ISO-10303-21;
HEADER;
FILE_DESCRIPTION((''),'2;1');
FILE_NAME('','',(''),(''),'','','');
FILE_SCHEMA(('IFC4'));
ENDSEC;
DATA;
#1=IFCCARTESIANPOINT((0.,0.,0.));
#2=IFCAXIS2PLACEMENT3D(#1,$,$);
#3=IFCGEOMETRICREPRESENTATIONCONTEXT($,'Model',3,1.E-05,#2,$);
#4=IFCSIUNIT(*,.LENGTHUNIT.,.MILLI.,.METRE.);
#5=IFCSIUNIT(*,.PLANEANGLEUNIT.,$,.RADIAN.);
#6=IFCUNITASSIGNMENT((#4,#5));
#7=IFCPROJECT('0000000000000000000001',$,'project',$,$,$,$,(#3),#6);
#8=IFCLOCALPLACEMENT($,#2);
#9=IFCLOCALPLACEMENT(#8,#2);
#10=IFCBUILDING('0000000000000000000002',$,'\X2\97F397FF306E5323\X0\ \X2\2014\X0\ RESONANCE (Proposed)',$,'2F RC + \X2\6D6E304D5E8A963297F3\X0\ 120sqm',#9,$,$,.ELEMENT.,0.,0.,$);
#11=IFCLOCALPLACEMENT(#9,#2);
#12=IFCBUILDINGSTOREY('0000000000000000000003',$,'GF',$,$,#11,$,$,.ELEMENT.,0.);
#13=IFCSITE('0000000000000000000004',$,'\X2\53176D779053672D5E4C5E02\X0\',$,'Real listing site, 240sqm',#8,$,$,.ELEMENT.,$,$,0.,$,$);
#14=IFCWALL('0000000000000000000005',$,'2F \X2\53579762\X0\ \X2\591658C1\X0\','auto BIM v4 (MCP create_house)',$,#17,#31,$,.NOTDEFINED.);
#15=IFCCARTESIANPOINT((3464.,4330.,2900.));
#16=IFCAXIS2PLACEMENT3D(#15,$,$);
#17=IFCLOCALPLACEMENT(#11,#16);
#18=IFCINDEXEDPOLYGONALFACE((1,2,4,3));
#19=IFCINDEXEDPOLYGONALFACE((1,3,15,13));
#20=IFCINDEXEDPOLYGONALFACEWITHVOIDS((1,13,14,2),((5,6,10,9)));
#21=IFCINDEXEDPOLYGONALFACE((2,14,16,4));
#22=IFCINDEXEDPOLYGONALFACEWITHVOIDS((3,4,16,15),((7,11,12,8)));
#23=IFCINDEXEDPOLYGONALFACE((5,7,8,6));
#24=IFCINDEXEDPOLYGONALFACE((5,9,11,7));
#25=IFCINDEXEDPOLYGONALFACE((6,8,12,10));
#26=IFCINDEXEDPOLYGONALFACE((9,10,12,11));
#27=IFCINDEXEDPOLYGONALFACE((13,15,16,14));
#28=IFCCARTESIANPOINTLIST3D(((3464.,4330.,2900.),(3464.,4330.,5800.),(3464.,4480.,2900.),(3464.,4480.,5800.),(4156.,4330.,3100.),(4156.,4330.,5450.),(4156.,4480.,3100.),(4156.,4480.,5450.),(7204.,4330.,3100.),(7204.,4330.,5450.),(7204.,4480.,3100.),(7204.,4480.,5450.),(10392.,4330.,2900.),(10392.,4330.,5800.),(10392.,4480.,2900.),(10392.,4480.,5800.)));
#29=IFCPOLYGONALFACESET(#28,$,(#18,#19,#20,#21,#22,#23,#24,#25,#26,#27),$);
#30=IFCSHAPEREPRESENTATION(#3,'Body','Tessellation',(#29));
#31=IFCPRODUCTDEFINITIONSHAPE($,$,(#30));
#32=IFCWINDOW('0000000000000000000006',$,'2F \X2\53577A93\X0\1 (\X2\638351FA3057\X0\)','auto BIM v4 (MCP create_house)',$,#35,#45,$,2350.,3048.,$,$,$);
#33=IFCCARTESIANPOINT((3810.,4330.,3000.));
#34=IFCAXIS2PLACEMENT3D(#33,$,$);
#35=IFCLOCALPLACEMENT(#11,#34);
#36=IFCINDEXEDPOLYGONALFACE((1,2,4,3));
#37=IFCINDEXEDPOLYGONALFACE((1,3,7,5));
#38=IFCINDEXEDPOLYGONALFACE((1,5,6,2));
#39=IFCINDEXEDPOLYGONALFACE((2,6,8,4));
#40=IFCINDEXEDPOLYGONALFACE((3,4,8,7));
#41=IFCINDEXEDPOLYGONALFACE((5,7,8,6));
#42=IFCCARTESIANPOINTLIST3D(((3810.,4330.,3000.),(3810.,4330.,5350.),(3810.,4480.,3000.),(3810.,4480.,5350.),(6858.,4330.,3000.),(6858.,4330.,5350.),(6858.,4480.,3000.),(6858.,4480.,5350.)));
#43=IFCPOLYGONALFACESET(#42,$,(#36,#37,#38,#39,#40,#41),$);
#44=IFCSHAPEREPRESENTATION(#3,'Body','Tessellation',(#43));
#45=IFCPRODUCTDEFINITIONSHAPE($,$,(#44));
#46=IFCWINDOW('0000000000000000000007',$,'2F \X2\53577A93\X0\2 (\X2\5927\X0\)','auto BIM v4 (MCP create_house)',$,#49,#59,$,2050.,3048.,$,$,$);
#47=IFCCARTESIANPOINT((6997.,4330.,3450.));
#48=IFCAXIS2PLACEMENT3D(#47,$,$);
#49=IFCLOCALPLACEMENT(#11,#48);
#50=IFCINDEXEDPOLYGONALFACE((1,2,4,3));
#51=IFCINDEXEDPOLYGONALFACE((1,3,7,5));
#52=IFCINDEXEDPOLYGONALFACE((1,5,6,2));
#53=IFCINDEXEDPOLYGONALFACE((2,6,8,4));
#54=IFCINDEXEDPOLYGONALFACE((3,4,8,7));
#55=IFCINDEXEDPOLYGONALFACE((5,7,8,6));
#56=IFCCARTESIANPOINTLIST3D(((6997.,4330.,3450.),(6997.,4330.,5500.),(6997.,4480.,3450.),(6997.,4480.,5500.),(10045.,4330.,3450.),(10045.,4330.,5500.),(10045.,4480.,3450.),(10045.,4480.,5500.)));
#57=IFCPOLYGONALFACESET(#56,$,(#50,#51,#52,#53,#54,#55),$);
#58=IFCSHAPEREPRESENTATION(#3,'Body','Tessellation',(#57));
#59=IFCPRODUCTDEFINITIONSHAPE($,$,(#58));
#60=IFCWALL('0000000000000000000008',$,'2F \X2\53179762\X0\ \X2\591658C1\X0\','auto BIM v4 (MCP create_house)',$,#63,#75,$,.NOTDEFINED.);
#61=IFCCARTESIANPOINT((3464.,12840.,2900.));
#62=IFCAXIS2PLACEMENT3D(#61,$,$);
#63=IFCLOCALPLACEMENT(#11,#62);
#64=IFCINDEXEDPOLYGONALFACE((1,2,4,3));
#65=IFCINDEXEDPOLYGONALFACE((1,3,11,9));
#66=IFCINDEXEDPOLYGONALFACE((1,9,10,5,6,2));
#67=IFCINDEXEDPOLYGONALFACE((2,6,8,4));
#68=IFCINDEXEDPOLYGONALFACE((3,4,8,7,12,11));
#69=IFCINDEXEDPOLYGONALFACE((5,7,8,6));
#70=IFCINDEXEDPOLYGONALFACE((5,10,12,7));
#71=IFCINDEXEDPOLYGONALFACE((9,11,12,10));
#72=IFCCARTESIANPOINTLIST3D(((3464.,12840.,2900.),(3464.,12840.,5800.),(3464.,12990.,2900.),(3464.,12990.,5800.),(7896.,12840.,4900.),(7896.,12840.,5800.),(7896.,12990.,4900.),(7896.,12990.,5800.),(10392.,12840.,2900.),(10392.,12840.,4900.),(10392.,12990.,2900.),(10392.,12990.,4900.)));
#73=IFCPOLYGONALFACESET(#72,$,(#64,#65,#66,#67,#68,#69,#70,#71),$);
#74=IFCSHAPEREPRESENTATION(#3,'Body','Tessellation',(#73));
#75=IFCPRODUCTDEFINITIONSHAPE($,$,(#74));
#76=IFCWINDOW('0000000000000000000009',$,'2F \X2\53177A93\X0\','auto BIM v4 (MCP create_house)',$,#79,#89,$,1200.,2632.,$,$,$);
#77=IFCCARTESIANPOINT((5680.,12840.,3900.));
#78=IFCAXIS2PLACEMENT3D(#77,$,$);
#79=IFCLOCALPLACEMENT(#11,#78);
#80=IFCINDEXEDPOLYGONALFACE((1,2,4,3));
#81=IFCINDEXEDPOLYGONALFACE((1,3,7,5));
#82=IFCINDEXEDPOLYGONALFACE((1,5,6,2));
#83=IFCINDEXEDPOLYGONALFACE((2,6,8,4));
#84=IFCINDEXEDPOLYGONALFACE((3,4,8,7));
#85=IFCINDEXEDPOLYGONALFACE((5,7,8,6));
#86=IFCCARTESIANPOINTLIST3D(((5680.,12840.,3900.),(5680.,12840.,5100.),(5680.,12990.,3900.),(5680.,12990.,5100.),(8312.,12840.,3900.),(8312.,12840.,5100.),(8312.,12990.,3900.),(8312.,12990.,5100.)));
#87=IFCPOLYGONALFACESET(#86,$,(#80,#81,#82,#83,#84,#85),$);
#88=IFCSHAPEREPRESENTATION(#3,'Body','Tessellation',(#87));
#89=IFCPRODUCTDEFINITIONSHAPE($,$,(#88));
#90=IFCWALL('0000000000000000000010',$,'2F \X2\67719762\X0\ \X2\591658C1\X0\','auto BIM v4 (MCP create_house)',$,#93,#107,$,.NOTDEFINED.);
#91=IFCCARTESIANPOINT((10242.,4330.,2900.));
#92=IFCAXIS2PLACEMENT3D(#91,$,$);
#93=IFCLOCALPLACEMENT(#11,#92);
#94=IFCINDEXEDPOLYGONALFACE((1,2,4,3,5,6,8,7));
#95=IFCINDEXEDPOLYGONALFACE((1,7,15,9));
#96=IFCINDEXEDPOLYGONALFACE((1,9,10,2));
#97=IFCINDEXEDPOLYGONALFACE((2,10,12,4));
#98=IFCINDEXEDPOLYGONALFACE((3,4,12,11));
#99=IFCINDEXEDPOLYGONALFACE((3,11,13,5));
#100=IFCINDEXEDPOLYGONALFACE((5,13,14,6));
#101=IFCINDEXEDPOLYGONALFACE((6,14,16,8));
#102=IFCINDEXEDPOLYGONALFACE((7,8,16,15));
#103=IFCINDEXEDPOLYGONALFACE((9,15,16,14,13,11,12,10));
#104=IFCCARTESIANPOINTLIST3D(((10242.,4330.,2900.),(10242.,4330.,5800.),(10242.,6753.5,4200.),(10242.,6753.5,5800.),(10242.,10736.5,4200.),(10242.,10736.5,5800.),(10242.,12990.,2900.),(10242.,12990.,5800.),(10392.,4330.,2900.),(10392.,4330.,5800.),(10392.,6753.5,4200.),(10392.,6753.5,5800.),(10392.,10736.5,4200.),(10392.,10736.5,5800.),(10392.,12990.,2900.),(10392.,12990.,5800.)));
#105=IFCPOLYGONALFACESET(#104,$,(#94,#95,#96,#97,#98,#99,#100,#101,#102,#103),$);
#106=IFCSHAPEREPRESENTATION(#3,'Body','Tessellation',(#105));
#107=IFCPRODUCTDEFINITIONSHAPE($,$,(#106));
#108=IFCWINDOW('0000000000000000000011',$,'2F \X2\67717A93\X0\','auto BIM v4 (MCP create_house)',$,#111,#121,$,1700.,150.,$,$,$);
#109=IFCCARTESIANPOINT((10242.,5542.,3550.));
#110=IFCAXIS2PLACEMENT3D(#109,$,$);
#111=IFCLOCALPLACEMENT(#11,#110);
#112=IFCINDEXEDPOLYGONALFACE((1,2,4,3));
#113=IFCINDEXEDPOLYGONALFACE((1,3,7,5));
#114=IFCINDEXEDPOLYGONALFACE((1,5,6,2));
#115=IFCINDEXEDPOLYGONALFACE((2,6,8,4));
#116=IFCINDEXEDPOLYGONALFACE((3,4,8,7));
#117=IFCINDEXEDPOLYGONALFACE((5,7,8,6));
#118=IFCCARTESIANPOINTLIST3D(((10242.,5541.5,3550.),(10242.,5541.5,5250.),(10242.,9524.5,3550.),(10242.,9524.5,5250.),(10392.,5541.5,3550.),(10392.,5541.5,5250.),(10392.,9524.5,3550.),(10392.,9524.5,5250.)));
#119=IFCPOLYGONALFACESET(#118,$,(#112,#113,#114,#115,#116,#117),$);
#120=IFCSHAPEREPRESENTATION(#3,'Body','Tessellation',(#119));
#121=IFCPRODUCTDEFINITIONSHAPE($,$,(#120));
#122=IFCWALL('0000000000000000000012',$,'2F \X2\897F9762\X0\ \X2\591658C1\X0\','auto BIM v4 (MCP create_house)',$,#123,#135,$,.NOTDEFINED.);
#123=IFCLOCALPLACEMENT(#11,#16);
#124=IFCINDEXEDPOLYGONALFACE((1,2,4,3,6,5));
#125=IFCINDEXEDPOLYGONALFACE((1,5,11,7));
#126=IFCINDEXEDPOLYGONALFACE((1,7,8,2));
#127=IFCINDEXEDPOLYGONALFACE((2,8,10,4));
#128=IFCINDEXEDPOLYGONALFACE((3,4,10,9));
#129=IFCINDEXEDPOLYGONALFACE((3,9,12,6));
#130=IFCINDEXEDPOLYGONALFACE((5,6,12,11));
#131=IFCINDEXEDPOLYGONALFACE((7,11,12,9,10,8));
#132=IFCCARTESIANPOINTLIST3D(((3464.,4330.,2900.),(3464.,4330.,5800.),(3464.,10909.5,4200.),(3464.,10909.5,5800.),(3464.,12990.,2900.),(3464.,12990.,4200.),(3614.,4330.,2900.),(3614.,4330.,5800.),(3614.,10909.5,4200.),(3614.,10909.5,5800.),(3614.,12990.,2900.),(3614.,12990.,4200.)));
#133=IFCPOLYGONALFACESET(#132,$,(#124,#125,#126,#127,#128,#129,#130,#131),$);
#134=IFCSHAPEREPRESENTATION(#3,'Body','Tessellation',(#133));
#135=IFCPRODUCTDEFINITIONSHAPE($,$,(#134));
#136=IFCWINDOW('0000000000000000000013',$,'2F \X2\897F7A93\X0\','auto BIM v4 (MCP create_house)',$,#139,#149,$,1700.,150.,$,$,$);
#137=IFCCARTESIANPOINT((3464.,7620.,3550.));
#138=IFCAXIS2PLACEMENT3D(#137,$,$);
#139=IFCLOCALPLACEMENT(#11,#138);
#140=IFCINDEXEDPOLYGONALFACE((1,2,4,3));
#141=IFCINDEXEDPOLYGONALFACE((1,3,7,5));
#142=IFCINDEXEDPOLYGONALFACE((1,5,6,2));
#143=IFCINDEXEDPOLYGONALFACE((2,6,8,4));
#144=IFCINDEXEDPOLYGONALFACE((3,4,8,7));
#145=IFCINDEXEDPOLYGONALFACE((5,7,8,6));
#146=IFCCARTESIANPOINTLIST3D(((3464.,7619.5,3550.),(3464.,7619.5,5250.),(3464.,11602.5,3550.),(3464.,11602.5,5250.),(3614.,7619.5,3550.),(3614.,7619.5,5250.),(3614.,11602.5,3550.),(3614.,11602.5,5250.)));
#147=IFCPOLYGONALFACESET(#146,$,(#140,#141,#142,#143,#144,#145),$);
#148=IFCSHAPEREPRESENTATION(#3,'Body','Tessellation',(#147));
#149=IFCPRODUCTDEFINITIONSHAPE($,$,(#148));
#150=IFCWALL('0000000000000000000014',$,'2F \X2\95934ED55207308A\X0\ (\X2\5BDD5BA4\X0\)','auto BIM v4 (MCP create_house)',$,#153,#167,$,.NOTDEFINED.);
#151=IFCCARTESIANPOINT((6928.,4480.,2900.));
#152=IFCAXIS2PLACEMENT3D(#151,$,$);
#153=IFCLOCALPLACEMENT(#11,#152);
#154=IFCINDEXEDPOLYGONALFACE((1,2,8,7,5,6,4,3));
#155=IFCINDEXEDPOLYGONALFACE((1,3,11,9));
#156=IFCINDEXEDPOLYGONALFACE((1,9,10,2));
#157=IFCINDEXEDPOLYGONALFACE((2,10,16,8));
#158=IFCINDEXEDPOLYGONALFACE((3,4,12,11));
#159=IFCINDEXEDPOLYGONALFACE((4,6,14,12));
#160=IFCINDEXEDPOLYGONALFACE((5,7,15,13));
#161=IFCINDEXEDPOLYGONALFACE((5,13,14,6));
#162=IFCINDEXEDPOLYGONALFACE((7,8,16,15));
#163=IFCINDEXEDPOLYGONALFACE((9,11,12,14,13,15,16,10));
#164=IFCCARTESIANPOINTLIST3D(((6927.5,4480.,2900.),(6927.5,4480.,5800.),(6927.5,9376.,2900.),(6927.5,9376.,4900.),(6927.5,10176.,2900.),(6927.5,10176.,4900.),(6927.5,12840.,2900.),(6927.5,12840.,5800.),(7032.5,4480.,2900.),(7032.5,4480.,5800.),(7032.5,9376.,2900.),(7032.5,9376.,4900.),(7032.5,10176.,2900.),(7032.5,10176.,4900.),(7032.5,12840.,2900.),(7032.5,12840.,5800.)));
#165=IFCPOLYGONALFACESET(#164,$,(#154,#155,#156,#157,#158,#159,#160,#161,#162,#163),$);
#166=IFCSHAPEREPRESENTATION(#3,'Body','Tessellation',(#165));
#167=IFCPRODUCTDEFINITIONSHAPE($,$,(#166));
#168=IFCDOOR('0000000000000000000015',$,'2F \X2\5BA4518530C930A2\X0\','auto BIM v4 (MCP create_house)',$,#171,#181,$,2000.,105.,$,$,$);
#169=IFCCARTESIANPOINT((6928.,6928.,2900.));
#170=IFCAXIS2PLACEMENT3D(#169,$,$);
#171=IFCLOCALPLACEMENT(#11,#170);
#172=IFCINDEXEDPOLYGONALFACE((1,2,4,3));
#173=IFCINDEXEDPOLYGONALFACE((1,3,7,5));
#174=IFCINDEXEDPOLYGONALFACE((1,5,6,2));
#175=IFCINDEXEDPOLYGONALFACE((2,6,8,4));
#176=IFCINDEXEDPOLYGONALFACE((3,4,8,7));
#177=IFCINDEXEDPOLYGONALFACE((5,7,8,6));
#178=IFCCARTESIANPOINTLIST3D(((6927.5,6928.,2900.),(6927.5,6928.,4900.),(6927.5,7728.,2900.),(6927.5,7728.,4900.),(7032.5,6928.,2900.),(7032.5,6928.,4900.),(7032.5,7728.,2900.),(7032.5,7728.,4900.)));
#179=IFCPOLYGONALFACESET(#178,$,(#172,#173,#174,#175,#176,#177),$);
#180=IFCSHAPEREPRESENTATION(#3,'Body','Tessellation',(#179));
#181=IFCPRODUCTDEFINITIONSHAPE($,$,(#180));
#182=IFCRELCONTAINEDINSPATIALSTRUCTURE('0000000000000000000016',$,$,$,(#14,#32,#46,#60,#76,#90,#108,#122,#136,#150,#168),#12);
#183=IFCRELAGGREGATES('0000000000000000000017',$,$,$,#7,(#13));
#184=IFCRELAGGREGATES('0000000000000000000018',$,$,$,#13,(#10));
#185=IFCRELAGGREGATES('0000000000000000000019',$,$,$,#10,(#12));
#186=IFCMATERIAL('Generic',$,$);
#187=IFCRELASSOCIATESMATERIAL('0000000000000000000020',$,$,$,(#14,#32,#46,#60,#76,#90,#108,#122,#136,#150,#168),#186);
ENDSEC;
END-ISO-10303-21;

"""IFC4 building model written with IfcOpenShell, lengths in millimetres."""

from ifc_helpers import new_model, si_unit, frame, frame_2d, origin, place, context, project, spatial, rectangle, extrude, material, element, fill, save


model = new_model("IFC4")

# Units and contexts
model_context = context("Model", 3, precision=1e-05, world=origin())
ifc_project = project(units=[si_unit("LENGTHUNIT", "METRE", prefix="MILLI"), si_unit("PLANEANGLEUNIT", "RADIAN")], contexts=[model_context])

# Site, building, storey
site_placement = place(None, origin())
site = spatial("IfcSite", under=ifc_project, at=site_placement, Name="北海道札幌市", ObjectType="Real listing site, 240sqm", CompositionType="ELEMENT", RefElevation=0.0)
building_placement = place(site_placement, origin())
building = spatial("IfcBuilding", under=site, at=building_placement, Name="音響の匣 — RESONANCE (Proposed)", ObjectType="2F RC + 浮き床防音 120sqm", CompositionType="ELEMENT", ElevationOfRefHeight=0.0, ElevationOfTerrain=0.0)
storey_placement = place(building_placement, origin())
storey = spatial("IfcBuildingStorey", under=building, at=storey_placement, Name="GF", CompositionType="ELEMENT", Elevation=0.0)

# Shared definitions
ifc_material = material(Name="Generic")

# Wall, openings, windows
wall_1_placement = place(storey_placement, frame((3464.0, 4330.0, 2900.0)))
wall_1 = element("IfcWall", 1, at=wall_1_placement, inside=storey, material=ifc_material, Name="2F 南面 外壁", Description="auto BIM v4 (MCP create_house)", PredefinedType="NOTDEFINED", context=model_context, shape_type="SweptSolid", body=[
    extrude(rectangle(XDim=6928.0, YDim=150.0, at=frame_2d((3464.0, 75.0))), frame((3464.0, 4330.0, 2900.0)), (0.0, 0.0, 1.0), 2900.0),
])
opening_1_placement = place(storey_placement, frame((3810.0, 4330.0, 3000.0)))
opening_1 = element("IfcOpeningElement", 2, at=opening_1_placement, cuts=wall_1, PredefinedType="NOTDEFINED", context=model_context, shape_type="SweptSolid", body=[
    extrude(rectangle(XDim=3048.0, YDim=150.0, at=frame_2d((1524.0, 75.0))), frame((3810.0, 4330.0, 3000.0)), (0.0, 0.0, 1.0), 2350.0),
])
opening_2_placement = place(storey_placement, frame((6997.0, 4330.0, 3450.0)))
opening_2 = element("IfcOpeningElement", 3, at=opening_2_placement, cuts=wall_1, PredefinedType="NOTDEFINED", context=model_context, shape_type="SweptSolid", body=[
    extrude(rectangle(XDim=3048.0, YDim=150.0, at=frame_2d((1524.0, 75.0))), frame((6997.0, 4330.0, 3450.0)), (0.0, 0.0, 1.0), 2050.0),
])
window_1_placement = place(storey_placement, frame((3810.0, 4330.0, 3000.0)))
window_1 = element("IfcWindow", 4, at=window_1_placement, inside=storey, material=ifc_material, Name="2F 南窓1 (掃出し)", Description="auto BIM v4 (MCP create_house)", OverallHeight=2350.0, OverallWidth=3048.0, context=model_context, shape_type="SweptSolid", body=[
    extrude(rectangle(XDim=3048.0, YDim=150.0, at=frame_2d((1524.0, 75.0))), frame((3810.0, 4330.0, 3000.0)), (0.0, 0.0, 1.0), 2350.0),
])
fill(opening_1, window_1)
window_2_placement = place(storey_placement, frame((6997.0, 4330.0, 3450.0)))
window_2 = element("IfcWindow", 5, at=window_2_placement, inside=storey, material=ifc_material, Name="2F 南窓2 (大)", Description="auto BIM v4 (MCP create_house)", OverallHeight=2050.0, OverallWidth=3048.0, context=model_context, shape_type="SweptSolid", body=[
    extrude(rectangle(XDim=3048.0, YDim=150.0, at=frame_2d((1524.0, 75.0))), frame((6997.0, 4330.0, 3450.0)), (0.0, 0.0, 1.0), 2050.0),
])
fill(opening_2, window_2)

# Walls, openings, windows
wall_2_placement = place(storey_placement, frame((3464.0, 12840.0, 2900.0)))
wall_2 = element("IfcWall", 6, at=wall_2_placement, inside=storey, material=ifc_material, Name="2F 北面 外壁", Description="auto BIM v4 (MCP create_house)", PredefinedType="NOTDEFINED", context=model_context, shape_type="SweptSolid", body=[
    extrude(rectangle(XDim=6928.0, YDim=150.0, at=frame_2d((3464.0, 75.0))), frame((3464.0, 12840.0, 2900.0)), (0.0, 0.0, 1.0), 2900.0),
])
opening_3_placement = place(storey_placement, frame((5680.0, 12840.0, 3900.0)))
opening_3 = element("IfcOpeningElement", 7, at=opening_3_placement, cuts=wall_2, PredefinedType="NOTDEFINED", context=model_context, shape_type="SweptSolid", body=[
    extrude(rectangle(XDim=2632.0, YDim=150.0, at=frame_2d((1316.0, 75.0))), frame((5680.0, 12840.0, 3900.0)), (0.0, 0.0, 1.0), 1200.0),
])
window_3_placement = place(storey_placement, frame((5680.0, 12840.0, 3900.0)))
window_3 = element("IfcWindow", 8, at=window_3_placement, inside=storey, material=ifc_material, Name="2F 北窓", Description="auto BIM v4 (MCP create_house)", OverallHeight=1200.0, OverallWidth=2632.0, context=model_context, shape_type="SweptSolid", body=[
    extrude(rectangle(XDim=2632.0, YDim=150.0, at=frame_2d((1316.0, 75.0))), frame((5680.0, 12840.0, 3900.0)), (0.0, 0.0, 1.0), 1200.0),
])
fill(opening_3, window_3)
wall_3_placement = place(storey_placement, frame((10242.0, 4330.0, 2900.0)))
wall_3 = element("IfcWall", 9, at=wall_3_placement, inside=storey, material=ifc_material, Name="2F 東面 外壁", Description="auto BIM v4 (MCP create_house)", PredefinedType="NOTDEFINED", context=model_context, shape_type="SweptSolid", body=[
    extrude(rectangle(XDim=150.0, YDim=8660.0, at=frame_2d((75.0, 4330.0))), frame((10242.0, 4330.0, 2900.0)), (0.0, 0.0, 1.0), 2900.0),
])
opening_4_placement = place(storey_placement, frame((10242.0, 5542.0, 3550.0)))
opening_4 = element("IfcOpeningElement", 10, at=opening_4_placement, cuts=wall_3, PredefinedType="NOTDEFINED", context=model_context, shape_type="SweptSolid", body=[
    extrude(rectangle(XDim=150.0, YDim=3983.0, at=frame_2d((75.0, 1991.0))), frame((10242.0, 5542.0, 3550.0)), (0.0, 0.0, 1.0), 1700.0),
])
window_4_placement = place(storey_placement, frame((10242.0, 5542.0, 3550.0)))
window_4 = element("IfcWindow", 11, at=window_4_placement, inside=storey, material=ifc_material, Name="2F 東窓", Description="auto BIM v4 (MCP create_house)", OverallHeight=1700.0, OverallWidth=150.0, context=model_context, shape_type="SweptSolid", body=[
    extrude(rectangle(XDim=150.0, YDim=3983.0, at=frame_2d((75.0, 1991.0))), frame((10242.0, 5542.0, 3550.0)), (0.0, 0.0, 1.0), 1700.0),
])
fill(opening_4, window_4)
wall_4_placement = place(storey_placement, frame((3464.0, 4330.0, 2900.0)))
wall_4 = element("IfcWall", 12, at=wall_4_placement, inside=storey, material=ifc_material, Name="2F 西面 外壁", Description="auto BIM v4 (MCP create_house)", PredefinedType="NOTDEFINED", context=model_context, shape_type="SweptSolid", body=[
    extrude(rectangle(XDim=150.0, YDim=8660.0, at=frame_2d((75.0, 4330.0))), frame((3464.0, 4330.0, 2900.0)), (0.0, 0.0, 1.0), 2900.0),
])
opening_5_placement = place(storey_placement, frame((3464.0, 7620.0, 3550.0)))
opening_5 = element("IfcOpeningElement", 13, at=opening_5_placement, cuts=wall_4, PredefinedType="NOTDEFINED", context=model_context, shape_type="SweptSolid", body=[
    extrude(rectangle(XDim=150.0, YDim=3983.0, at=frame_2d((75.0, 1991.0))), frame((3464.0, 7620.0, 3550.0)), (0.0, 0.0, 1.0), 1700.0),
])
window_5_placement = place(storey_placement, frame((3464.0, 7620.0, 3550.0)))
window_5 = element("IfcWindow", 14, at=window_5_placement, inside=storey, material=ifc_material, Name="2F 西窓", Description="auto BIM v4 (MCP create_house)", OverallHeight=1700.0, OverallWidth=150.0, context=model_context, shape_type="SweptSolid", body=[
    extrude(rectangle(XDim=150.0, YDim=3983.0, at=frame_2d((75.0, 1991.0))), frame((3464.0, 7620.0, 3550.0)), (0.0, 0.0, 1.0), 1700.0),
])
fill(opening_5, window_5)

# Wall, opening, door
wall_5_placement = place(storey_placement, frame((6928.0, 4480.0, 2900.0)))
wall_5 = element("IfcWall", 15, at=wall_5_placement, inside=storey, material=ifc_material, Name="2F 間仕切り (寝室)", Description="auto BIM v4 (MCP create_house)", PredefinedType="NOTDEFINED", context=model_context, shape_type="SweptSolid", body=[
    extrude(rectangle(XDim=105.0, YDim=8360.0, at=frame_2d((52.0, 4180.0))), frame((6928.0, 4480.0, 2900.0)), (0.0, 0.0, 1.0), 2900.0),
])
opening_6_placement = place(storey_placement, frame((6928.0, 6928.0, 2900.0)))
opening_6 = element("IfcOpeningElement", 16, at=opening_6_placement, cuts=wall_5, PredefinedType="NOTDEFINED", context=model_context, shape_type="SweptSolid", body=[
    extrude(rectangle(XDim=105.0, YDim=800.0, at=frame_2d((52.0, 400.0))), frame((6928.0, 6928.0, 2900.0)), (0.0, 0.0, 1.0), 2000.0),
])
door_1_placement = place(storey_placement, frame((6928.0, 6928.0, 2900.0)))
door_1 = element("IfcDoor", 17, at=door_1_placement, inside=storey, material=ifc_material, Name="2F 室内ドア", Description="auto BIM v4 (MCP create_house)", OverallHeight=2000.0, OverallWidth=105.0, context=model_context, shape_type="SweptSolid", body=[
    extrude(rectangle(XDim=105.0, YDim=800.0, at=frame_2d((52.0, 400.0))), frame((6928.0, 6928.0, 2900.0)), (0.0, 0.0, 1.0), 2000.0),
])
fill(opening_6, door_1)

save(model, "model.ifc")
